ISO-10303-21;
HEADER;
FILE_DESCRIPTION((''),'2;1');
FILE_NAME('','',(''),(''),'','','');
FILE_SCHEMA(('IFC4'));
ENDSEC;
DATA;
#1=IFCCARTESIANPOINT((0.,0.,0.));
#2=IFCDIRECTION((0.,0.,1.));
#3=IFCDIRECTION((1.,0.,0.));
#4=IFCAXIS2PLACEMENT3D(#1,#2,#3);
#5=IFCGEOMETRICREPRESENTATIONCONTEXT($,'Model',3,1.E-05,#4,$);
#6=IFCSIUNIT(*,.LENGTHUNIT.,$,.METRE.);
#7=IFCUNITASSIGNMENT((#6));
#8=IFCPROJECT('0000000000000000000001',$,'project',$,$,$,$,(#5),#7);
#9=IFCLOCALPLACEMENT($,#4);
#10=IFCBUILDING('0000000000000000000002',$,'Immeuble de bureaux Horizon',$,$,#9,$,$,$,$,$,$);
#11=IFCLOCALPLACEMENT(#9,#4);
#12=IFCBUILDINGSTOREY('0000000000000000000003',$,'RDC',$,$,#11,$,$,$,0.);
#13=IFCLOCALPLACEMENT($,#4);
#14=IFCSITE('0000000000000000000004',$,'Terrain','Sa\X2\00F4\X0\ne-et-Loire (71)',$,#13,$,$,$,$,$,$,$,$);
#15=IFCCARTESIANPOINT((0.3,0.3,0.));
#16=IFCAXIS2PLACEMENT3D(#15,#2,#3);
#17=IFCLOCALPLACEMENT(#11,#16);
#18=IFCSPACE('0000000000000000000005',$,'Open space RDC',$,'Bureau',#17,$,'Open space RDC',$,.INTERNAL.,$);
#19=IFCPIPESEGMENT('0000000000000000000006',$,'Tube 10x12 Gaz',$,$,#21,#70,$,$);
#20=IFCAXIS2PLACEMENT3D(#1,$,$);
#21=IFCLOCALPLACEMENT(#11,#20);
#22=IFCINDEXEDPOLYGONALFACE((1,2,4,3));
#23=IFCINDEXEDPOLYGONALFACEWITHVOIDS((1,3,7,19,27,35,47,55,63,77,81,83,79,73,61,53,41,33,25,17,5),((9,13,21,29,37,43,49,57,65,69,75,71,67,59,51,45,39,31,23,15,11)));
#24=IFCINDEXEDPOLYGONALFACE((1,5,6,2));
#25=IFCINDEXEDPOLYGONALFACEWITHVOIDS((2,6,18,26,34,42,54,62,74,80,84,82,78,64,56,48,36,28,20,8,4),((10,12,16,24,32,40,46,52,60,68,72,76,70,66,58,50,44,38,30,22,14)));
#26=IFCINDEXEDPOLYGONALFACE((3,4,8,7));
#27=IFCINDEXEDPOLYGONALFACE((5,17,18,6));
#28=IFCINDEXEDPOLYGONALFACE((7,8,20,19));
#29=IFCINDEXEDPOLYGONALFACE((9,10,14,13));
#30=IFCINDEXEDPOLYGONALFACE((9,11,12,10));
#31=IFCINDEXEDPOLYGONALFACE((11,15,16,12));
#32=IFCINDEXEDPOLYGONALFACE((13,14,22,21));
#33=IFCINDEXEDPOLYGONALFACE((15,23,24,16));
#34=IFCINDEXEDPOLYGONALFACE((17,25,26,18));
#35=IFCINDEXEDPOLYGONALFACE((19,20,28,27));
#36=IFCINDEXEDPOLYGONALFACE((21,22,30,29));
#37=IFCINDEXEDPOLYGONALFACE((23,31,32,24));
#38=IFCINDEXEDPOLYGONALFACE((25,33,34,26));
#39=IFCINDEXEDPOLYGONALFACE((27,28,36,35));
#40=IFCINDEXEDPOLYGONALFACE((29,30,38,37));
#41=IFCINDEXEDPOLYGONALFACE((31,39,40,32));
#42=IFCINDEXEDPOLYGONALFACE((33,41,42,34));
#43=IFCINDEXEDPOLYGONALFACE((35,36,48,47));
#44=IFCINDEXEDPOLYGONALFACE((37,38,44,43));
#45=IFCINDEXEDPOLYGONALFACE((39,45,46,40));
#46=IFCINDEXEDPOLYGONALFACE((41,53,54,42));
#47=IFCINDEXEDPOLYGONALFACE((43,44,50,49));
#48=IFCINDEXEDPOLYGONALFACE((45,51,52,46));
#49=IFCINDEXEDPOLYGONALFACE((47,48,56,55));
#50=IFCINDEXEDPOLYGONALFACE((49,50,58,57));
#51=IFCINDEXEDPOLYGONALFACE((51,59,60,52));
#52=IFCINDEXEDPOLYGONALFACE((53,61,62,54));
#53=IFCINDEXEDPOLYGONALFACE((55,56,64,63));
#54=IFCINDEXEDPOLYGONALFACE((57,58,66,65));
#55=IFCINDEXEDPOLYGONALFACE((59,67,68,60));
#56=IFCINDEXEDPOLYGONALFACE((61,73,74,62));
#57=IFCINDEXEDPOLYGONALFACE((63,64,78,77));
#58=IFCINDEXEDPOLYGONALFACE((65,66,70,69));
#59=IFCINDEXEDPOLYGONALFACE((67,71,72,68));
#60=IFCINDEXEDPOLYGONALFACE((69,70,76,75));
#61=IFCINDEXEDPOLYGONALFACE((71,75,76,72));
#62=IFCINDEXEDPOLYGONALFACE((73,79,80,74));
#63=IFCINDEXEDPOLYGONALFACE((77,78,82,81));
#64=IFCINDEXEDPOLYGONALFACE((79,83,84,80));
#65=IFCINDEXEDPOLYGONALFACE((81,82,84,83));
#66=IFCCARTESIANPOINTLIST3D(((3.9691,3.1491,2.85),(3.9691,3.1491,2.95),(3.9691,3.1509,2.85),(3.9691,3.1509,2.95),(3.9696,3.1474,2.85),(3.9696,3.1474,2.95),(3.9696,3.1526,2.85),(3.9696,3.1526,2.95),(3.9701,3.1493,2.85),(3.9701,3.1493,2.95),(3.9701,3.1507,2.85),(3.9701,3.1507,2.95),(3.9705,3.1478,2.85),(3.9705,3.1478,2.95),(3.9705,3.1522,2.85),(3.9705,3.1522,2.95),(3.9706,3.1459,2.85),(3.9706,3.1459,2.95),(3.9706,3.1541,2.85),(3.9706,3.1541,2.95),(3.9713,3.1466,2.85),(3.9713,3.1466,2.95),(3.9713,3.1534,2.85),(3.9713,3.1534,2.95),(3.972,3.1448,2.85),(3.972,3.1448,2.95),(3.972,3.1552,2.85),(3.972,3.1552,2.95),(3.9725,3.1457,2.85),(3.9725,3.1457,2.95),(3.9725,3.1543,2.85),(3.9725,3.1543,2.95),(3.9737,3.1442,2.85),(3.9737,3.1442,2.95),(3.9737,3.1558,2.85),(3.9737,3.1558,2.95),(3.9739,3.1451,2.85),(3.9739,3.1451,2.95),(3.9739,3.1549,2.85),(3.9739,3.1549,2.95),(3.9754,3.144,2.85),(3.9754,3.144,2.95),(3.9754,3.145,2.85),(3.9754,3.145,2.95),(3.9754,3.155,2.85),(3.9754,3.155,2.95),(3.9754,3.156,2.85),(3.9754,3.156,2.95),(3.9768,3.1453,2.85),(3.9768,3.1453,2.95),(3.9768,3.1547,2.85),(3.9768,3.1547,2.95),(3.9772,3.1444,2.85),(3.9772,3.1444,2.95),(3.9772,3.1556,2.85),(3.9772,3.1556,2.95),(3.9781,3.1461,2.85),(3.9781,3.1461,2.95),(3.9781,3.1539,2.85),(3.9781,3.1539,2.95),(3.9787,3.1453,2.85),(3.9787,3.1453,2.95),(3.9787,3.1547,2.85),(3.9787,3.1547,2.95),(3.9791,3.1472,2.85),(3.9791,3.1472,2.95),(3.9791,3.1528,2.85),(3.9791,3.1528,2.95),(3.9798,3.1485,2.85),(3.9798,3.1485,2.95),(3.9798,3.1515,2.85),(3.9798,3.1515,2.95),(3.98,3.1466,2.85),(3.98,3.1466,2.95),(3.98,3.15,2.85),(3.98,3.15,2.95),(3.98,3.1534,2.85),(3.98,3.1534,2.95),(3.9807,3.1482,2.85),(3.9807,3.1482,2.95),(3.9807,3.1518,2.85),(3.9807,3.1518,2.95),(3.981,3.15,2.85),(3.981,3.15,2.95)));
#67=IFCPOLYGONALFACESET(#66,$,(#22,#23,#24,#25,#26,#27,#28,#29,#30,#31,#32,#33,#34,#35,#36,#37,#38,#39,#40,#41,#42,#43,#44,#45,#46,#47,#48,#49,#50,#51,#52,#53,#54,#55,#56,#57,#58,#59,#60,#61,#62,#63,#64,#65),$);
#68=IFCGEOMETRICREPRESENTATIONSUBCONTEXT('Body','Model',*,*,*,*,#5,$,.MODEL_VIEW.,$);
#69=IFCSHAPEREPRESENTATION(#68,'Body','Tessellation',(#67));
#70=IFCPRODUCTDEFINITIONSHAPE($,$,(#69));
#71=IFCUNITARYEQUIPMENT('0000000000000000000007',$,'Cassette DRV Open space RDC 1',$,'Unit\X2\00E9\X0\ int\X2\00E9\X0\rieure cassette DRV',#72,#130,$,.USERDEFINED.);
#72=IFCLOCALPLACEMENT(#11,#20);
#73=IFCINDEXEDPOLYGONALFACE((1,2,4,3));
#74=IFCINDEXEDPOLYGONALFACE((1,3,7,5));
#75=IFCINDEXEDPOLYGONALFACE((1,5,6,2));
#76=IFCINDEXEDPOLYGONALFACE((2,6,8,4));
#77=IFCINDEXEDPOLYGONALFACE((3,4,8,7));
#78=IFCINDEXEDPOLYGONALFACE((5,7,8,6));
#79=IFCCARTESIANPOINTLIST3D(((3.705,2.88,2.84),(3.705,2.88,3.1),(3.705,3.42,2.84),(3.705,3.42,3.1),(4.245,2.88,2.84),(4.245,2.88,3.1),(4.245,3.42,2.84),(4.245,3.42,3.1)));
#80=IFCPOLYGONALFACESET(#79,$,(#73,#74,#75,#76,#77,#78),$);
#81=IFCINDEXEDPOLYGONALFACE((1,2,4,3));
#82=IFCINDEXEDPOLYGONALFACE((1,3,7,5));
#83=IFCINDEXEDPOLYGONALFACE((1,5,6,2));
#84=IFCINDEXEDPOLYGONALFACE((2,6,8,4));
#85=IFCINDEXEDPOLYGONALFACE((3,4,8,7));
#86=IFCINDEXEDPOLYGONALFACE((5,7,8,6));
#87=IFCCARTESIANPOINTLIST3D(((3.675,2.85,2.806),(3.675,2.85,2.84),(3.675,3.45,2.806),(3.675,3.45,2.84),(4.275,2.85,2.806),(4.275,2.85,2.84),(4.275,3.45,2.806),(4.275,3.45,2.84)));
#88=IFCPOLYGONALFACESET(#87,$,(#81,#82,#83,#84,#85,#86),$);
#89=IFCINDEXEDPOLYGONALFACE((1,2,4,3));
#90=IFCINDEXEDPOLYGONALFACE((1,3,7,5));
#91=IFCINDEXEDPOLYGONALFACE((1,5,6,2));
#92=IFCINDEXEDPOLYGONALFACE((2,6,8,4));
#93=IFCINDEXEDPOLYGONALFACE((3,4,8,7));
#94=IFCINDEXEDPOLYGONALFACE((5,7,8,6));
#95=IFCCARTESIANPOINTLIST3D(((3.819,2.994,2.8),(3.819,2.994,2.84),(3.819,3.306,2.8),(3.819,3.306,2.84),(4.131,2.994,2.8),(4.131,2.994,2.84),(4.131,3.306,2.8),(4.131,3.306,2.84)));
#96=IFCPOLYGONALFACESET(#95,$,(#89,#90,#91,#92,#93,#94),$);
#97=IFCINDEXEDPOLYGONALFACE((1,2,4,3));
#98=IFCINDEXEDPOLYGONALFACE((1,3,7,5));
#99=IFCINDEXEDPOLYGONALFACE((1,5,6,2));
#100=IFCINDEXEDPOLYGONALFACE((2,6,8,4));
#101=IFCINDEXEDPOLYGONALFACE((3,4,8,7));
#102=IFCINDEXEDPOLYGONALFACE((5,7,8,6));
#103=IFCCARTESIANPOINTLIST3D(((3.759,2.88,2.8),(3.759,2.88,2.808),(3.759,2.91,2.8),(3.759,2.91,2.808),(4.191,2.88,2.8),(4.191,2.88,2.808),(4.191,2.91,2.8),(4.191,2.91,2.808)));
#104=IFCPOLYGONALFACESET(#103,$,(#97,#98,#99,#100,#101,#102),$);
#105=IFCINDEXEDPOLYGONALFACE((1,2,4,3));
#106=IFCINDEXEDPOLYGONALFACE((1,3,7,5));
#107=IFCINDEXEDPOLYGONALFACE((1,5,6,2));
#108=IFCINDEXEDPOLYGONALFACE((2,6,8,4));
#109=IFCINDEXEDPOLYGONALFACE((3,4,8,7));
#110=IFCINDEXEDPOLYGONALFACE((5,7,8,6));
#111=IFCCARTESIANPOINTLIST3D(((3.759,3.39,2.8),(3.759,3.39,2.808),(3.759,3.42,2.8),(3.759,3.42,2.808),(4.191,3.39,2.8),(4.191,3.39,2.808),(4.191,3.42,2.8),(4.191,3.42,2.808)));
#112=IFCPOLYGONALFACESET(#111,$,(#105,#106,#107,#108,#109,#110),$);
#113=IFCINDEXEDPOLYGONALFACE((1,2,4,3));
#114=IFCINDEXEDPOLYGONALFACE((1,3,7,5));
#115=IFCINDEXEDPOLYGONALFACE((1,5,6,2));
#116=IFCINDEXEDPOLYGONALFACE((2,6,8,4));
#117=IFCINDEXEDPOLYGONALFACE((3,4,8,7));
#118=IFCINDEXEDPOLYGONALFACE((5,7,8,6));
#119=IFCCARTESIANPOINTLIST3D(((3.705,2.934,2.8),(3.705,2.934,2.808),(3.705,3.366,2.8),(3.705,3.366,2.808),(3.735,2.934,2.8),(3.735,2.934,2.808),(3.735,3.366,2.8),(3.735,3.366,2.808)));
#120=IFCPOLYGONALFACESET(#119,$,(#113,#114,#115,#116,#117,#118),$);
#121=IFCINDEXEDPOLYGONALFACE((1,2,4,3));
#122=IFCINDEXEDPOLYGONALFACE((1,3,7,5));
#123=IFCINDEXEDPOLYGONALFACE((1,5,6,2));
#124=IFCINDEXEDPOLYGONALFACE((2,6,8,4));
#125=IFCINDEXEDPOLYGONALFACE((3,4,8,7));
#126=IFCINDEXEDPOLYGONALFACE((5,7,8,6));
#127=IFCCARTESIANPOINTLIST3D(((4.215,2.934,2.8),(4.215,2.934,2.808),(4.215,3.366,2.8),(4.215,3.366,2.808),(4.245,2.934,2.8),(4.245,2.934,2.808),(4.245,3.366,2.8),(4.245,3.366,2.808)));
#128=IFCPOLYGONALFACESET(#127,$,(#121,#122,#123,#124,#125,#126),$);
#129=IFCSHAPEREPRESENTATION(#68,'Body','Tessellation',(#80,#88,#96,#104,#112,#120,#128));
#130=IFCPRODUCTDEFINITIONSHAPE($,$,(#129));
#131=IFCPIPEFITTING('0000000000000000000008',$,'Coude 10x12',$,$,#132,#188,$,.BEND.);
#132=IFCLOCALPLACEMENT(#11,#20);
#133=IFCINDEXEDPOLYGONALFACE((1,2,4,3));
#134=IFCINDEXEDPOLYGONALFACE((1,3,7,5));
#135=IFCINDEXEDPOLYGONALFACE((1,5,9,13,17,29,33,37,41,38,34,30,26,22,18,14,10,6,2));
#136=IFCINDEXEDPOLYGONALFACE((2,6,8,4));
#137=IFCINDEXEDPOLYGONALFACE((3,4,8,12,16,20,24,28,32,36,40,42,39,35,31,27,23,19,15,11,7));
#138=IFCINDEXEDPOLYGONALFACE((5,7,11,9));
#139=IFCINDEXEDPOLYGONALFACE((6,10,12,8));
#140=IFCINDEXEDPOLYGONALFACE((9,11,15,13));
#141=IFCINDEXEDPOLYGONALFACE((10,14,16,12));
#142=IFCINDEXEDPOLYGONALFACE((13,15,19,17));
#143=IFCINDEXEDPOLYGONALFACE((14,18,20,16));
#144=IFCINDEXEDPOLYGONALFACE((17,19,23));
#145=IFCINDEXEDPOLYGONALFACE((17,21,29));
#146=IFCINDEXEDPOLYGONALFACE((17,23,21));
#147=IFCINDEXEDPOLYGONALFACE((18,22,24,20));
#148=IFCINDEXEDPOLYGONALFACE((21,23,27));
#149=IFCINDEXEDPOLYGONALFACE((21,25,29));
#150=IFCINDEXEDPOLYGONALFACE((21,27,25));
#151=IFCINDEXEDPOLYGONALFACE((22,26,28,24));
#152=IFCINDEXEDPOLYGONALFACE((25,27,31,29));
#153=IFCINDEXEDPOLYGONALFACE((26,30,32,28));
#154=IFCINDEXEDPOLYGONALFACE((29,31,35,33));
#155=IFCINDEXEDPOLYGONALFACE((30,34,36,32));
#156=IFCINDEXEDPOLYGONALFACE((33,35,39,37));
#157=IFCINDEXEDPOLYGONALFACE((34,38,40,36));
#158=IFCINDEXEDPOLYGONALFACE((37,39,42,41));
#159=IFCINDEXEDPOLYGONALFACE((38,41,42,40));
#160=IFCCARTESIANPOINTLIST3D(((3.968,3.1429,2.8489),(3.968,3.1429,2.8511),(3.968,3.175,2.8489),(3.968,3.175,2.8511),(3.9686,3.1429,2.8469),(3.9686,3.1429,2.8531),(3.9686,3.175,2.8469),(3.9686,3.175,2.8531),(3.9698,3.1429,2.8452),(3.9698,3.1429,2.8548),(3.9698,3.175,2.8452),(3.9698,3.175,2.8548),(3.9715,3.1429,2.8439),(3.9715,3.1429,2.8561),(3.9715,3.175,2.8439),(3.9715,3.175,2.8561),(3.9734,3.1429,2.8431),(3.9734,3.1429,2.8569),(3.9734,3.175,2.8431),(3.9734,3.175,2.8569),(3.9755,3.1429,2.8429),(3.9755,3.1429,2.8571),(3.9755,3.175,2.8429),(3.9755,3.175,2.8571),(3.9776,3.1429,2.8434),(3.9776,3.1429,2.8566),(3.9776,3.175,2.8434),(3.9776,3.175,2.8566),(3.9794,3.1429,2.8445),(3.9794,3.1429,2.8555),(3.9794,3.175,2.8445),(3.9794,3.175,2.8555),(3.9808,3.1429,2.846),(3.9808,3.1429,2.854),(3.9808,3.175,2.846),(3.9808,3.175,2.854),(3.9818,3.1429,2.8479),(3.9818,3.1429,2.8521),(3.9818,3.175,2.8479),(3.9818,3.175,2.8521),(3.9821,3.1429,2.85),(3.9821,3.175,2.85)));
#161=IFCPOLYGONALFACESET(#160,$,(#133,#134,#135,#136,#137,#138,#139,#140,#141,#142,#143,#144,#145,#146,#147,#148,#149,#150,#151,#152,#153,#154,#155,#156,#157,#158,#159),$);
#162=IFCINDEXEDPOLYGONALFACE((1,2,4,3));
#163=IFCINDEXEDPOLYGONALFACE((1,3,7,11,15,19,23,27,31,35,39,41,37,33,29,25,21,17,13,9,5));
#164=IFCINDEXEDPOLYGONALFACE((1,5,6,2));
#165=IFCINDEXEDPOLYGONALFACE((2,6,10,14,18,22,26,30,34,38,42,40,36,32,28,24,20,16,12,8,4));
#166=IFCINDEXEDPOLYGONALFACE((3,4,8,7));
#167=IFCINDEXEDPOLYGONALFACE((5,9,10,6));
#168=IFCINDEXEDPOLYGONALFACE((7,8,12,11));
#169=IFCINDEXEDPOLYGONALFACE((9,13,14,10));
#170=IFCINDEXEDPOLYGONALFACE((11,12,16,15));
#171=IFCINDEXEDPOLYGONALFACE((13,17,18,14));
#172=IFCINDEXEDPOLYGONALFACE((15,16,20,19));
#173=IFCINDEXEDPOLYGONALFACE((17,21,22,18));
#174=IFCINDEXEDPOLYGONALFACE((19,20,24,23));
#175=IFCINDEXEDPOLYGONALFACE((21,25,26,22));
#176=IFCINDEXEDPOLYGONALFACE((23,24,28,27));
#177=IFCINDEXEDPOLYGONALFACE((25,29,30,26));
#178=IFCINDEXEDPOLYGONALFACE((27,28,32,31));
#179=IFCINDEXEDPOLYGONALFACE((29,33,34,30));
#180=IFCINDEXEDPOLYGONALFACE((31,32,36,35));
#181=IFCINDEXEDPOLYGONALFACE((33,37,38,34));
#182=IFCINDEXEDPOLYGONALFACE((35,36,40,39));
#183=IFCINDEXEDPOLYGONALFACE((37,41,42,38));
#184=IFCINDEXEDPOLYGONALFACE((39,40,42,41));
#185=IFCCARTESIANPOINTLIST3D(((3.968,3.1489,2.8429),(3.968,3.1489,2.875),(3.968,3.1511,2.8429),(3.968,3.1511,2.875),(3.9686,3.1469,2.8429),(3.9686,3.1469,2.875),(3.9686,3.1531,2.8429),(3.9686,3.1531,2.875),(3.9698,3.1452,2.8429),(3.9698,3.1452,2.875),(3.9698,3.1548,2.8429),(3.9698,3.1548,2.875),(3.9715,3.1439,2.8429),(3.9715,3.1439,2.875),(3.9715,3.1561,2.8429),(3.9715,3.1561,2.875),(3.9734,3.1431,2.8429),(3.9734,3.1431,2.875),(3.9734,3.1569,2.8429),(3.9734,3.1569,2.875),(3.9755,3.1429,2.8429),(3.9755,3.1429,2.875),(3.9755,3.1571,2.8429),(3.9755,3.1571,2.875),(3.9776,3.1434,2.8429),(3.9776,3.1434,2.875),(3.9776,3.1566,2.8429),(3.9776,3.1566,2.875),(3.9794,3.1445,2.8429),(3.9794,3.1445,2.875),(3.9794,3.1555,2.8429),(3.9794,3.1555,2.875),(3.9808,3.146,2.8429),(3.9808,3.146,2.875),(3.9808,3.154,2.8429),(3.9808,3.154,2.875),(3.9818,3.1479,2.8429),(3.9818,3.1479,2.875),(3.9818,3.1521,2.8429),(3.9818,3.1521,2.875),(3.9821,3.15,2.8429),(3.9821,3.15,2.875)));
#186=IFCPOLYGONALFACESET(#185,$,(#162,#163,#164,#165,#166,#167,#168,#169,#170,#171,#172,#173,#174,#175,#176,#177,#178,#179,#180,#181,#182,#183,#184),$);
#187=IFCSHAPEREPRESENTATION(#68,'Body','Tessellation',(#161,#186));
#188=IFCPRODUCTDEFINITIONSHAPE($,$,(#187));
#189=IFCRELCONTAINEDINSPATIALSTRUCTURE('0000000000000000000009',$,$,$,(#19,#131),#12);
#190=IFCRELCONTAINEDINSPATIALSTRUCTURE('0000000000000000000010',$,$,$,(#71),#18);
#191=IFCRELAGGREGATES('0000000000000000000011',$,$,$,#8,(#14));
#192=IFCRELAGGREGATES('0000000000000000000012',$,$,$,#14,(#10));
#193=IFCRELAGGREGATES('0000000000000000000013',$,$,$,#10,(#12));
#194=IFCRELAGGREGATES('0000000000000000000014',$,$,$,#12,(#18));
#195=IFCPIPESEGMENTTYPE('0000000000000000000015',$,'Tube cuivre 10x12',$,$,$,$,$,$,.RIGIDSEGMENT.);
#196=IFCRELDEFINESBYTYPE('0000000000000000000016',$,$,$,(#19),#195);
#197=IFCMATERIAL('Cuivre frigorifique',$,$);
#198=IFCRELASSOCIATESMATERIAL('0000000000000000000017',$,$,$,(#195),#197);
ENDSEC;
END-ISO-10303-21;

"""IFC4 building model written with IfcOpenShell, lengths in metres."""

from ifc_helpers import new_model, si_unit, frame, frame_2d, origin_with_axes, place, context, subcontext, project, spatial, rectangle, circle, hollow_circle, extrude, material, type_object, element, save


model = new_model("IFC4")

# Units and contexts
model_context = context("Model", 3, precision=1e-05, world=origin_with_axes())
body_context = subcontext(model_context, "Body", "Model", "MODEL_VIEW")
ifc_project = project(units=[si_unit("LENGTHUNIT", "METRE")], contexts=[model_context])

# Site, building, storey
site_placement = place(None, origin_with_axes())
site = spatial("IfcSite", under=ifc_project, at=site_placement, Name="Terrain", Description="Saône-et-Loire (71)")
building_placement = place(None, origin_with_axes())
building = spatial("IfcBuilding", under=site, at=building_placement, Name="Immeuble de bureaux Horizon")
storey_placement = place(building_placement, origin_with_axes())
storey = spatial("IfcBuildingStorey", under=building, at=storey_placement, Name="RDC", Elevation=0.0)

# Pipe segment
ifc_material_1 = material(Name="Cuivre frigorifique")
pipe_segment_type = type_object("IfcPipeSegmentType", Name="Tube cuivre 10x12", PredefinedType="RIGIDSEGMENT", material=ifc_material_1)
pipe_segment_placement = place(storey_placement, frame((3.975, 3.15, 2.85), z_axis=(0.0, 0.0, 1.0), x_axis=(1.0, 0.0, 0.0)))
element("IfcPipeSegment", 1, at=pipe_segment_placement, inside=storey, type_object=pipe_segment_type, Name="Tube 10x12 Gaz", context=body_context, shape_type="SweptSolid", body=[
    extrude(hollow_circle(Radius=0.006, WallThickness=0.001), origin_with_axes(), (0.0, 0.0, 1.0), 0.1),
])

# Shared definitions
space_placement = place(storey_placement, frame((0.3, 0.3, 0.0), z_axis=(0.0, 0.0, 1.0), x_axis=(1.0, 0.0, 0.0)))
space = spatial("IfcSpace", under=storey, at=space_placement, Name="Open space RDC", ObjectType="Bureau", LongName="Open space RDC", PredefinedType="INTERNAL")

# Unitary equipment
unitary_equipment_placement = place(space_placement, frame((3.375, 2.55, 2.8), z_axis=(0.0, 0.0, 1.0), x_axis=(1.0, 0.0, 0.0)))
element("IfcUnitaryEquipment", 2, at=unitary_equipment_placement, inside=space, Name="Cassette DRV Open space RDC 1", ObjectType="Unité intérieure cassette DRV", PredefinedType="USERDEFINED", context=body_context, shape_type="SweptSolid", body=[
    extrude(rectangle(XDim=0.54, YDim=0.54, at=frame_2d((0.27, 0.27))), frame((0.03, 0.03, 0.04), z_axis=(0.0, 0.0, 1.0), x_axis=(1.0, 0.0, 0.0)), (0.0, 0.0, 1.0), 0.26),
    extrude(rectangle(XDim=0.6, YDim=0.6, at=frame_2d((0.3, 0.3))), frame((0.0, 0.0, 0.006), z_axis=(0.0, 0.0, 1.0), x_axis=(1.0, 0.0, 0.0)), (0.0, 0.0, 1.0), 0.034),
    extrude(rectangle(XDim=0.312, YDim=0.312, at=frame_2d((0.156, 0.156))), frame((0.144, 0.144, 0.0), z_axis=(0.0, 0.0, 1.0), x_axis=(1.0, 0.0, 0.0)), (0.0, 0.0, 1.0), 0.04),
    extrude(rectangle(XDim=0.432, YDim=0.03, at=frame_2d((0.216, 0.015))), frame((0.084, 0.03, 0.0), z_axis=(0.0, 0.0, 1.0), x_axis=(1.0, 0.0, 0.0)), (0.0, 0.0, 1.0), 0.008),
    extrude(rectangle(XDim=0.432, YDim=0.03, at=frame_2d((0.216, 0.015))), frame((0.084, 0.54, 0.0), z_axis=(0.0, 0.0, 1.0), x_axis=(1.0, 0.0, 0.0)), (0.0, 0.0, 1.0), 0.008),
    extrude(rectangle(XDim=0.03, YDim=0.432, at=frame_2d((0.015, 0.216))), frame((0.03, 0.084, 0.0), z_axis=(0.0, 0.0, 1.0), x_axis=(1.0, 0.0, 0.0)), (0.0, 0.0, 1.0), 0.008),
    extrude(rectangle(XDim=0.03, YDim=0.432, at=frame_2d((0.015, 0.216))), frame((0.54, 0.084, 0.0), z_axis=(0.0, 0.0, 1.0), x_axis=(1.0, 0.0, 0.0)), (0.0, 0.0, 1.0), 0.008),
])

# Pipe fitting
pipe_fitting_placement = place(storey_placement, frame((3.975, 3.15, 2.85), z_axis=(0.0, 0.0, 1.0), x_axis=(1.0, 0.0, 0.0)))
element("IfcPipeFitting", 3, at=pipe_fitting_placement, inside=storey, Name="Coude 10x12", PredefinedType="BEND", context=body_context, shape_type="SweptSolid", body=[
    extrude(circle(Radius=0.0071), frame((0.0, -0.0071, 0.0), z_axis=(0.0, 1.0, 0.0), x_axis=(1.0, 0.0, 0.0)), (0.0, 0.0, 1.0), 0.0321),
    extrude(circle(Radius=0.0071), frame((0.0, 0.0, -0.0071), z_axis=(0.0, 0.0, 1.0), x_axis=(1.0, 0.0, 0.0)), (0.0, 0.0, 1.0), 0.0321),
])

save(model, "model.ifc")
